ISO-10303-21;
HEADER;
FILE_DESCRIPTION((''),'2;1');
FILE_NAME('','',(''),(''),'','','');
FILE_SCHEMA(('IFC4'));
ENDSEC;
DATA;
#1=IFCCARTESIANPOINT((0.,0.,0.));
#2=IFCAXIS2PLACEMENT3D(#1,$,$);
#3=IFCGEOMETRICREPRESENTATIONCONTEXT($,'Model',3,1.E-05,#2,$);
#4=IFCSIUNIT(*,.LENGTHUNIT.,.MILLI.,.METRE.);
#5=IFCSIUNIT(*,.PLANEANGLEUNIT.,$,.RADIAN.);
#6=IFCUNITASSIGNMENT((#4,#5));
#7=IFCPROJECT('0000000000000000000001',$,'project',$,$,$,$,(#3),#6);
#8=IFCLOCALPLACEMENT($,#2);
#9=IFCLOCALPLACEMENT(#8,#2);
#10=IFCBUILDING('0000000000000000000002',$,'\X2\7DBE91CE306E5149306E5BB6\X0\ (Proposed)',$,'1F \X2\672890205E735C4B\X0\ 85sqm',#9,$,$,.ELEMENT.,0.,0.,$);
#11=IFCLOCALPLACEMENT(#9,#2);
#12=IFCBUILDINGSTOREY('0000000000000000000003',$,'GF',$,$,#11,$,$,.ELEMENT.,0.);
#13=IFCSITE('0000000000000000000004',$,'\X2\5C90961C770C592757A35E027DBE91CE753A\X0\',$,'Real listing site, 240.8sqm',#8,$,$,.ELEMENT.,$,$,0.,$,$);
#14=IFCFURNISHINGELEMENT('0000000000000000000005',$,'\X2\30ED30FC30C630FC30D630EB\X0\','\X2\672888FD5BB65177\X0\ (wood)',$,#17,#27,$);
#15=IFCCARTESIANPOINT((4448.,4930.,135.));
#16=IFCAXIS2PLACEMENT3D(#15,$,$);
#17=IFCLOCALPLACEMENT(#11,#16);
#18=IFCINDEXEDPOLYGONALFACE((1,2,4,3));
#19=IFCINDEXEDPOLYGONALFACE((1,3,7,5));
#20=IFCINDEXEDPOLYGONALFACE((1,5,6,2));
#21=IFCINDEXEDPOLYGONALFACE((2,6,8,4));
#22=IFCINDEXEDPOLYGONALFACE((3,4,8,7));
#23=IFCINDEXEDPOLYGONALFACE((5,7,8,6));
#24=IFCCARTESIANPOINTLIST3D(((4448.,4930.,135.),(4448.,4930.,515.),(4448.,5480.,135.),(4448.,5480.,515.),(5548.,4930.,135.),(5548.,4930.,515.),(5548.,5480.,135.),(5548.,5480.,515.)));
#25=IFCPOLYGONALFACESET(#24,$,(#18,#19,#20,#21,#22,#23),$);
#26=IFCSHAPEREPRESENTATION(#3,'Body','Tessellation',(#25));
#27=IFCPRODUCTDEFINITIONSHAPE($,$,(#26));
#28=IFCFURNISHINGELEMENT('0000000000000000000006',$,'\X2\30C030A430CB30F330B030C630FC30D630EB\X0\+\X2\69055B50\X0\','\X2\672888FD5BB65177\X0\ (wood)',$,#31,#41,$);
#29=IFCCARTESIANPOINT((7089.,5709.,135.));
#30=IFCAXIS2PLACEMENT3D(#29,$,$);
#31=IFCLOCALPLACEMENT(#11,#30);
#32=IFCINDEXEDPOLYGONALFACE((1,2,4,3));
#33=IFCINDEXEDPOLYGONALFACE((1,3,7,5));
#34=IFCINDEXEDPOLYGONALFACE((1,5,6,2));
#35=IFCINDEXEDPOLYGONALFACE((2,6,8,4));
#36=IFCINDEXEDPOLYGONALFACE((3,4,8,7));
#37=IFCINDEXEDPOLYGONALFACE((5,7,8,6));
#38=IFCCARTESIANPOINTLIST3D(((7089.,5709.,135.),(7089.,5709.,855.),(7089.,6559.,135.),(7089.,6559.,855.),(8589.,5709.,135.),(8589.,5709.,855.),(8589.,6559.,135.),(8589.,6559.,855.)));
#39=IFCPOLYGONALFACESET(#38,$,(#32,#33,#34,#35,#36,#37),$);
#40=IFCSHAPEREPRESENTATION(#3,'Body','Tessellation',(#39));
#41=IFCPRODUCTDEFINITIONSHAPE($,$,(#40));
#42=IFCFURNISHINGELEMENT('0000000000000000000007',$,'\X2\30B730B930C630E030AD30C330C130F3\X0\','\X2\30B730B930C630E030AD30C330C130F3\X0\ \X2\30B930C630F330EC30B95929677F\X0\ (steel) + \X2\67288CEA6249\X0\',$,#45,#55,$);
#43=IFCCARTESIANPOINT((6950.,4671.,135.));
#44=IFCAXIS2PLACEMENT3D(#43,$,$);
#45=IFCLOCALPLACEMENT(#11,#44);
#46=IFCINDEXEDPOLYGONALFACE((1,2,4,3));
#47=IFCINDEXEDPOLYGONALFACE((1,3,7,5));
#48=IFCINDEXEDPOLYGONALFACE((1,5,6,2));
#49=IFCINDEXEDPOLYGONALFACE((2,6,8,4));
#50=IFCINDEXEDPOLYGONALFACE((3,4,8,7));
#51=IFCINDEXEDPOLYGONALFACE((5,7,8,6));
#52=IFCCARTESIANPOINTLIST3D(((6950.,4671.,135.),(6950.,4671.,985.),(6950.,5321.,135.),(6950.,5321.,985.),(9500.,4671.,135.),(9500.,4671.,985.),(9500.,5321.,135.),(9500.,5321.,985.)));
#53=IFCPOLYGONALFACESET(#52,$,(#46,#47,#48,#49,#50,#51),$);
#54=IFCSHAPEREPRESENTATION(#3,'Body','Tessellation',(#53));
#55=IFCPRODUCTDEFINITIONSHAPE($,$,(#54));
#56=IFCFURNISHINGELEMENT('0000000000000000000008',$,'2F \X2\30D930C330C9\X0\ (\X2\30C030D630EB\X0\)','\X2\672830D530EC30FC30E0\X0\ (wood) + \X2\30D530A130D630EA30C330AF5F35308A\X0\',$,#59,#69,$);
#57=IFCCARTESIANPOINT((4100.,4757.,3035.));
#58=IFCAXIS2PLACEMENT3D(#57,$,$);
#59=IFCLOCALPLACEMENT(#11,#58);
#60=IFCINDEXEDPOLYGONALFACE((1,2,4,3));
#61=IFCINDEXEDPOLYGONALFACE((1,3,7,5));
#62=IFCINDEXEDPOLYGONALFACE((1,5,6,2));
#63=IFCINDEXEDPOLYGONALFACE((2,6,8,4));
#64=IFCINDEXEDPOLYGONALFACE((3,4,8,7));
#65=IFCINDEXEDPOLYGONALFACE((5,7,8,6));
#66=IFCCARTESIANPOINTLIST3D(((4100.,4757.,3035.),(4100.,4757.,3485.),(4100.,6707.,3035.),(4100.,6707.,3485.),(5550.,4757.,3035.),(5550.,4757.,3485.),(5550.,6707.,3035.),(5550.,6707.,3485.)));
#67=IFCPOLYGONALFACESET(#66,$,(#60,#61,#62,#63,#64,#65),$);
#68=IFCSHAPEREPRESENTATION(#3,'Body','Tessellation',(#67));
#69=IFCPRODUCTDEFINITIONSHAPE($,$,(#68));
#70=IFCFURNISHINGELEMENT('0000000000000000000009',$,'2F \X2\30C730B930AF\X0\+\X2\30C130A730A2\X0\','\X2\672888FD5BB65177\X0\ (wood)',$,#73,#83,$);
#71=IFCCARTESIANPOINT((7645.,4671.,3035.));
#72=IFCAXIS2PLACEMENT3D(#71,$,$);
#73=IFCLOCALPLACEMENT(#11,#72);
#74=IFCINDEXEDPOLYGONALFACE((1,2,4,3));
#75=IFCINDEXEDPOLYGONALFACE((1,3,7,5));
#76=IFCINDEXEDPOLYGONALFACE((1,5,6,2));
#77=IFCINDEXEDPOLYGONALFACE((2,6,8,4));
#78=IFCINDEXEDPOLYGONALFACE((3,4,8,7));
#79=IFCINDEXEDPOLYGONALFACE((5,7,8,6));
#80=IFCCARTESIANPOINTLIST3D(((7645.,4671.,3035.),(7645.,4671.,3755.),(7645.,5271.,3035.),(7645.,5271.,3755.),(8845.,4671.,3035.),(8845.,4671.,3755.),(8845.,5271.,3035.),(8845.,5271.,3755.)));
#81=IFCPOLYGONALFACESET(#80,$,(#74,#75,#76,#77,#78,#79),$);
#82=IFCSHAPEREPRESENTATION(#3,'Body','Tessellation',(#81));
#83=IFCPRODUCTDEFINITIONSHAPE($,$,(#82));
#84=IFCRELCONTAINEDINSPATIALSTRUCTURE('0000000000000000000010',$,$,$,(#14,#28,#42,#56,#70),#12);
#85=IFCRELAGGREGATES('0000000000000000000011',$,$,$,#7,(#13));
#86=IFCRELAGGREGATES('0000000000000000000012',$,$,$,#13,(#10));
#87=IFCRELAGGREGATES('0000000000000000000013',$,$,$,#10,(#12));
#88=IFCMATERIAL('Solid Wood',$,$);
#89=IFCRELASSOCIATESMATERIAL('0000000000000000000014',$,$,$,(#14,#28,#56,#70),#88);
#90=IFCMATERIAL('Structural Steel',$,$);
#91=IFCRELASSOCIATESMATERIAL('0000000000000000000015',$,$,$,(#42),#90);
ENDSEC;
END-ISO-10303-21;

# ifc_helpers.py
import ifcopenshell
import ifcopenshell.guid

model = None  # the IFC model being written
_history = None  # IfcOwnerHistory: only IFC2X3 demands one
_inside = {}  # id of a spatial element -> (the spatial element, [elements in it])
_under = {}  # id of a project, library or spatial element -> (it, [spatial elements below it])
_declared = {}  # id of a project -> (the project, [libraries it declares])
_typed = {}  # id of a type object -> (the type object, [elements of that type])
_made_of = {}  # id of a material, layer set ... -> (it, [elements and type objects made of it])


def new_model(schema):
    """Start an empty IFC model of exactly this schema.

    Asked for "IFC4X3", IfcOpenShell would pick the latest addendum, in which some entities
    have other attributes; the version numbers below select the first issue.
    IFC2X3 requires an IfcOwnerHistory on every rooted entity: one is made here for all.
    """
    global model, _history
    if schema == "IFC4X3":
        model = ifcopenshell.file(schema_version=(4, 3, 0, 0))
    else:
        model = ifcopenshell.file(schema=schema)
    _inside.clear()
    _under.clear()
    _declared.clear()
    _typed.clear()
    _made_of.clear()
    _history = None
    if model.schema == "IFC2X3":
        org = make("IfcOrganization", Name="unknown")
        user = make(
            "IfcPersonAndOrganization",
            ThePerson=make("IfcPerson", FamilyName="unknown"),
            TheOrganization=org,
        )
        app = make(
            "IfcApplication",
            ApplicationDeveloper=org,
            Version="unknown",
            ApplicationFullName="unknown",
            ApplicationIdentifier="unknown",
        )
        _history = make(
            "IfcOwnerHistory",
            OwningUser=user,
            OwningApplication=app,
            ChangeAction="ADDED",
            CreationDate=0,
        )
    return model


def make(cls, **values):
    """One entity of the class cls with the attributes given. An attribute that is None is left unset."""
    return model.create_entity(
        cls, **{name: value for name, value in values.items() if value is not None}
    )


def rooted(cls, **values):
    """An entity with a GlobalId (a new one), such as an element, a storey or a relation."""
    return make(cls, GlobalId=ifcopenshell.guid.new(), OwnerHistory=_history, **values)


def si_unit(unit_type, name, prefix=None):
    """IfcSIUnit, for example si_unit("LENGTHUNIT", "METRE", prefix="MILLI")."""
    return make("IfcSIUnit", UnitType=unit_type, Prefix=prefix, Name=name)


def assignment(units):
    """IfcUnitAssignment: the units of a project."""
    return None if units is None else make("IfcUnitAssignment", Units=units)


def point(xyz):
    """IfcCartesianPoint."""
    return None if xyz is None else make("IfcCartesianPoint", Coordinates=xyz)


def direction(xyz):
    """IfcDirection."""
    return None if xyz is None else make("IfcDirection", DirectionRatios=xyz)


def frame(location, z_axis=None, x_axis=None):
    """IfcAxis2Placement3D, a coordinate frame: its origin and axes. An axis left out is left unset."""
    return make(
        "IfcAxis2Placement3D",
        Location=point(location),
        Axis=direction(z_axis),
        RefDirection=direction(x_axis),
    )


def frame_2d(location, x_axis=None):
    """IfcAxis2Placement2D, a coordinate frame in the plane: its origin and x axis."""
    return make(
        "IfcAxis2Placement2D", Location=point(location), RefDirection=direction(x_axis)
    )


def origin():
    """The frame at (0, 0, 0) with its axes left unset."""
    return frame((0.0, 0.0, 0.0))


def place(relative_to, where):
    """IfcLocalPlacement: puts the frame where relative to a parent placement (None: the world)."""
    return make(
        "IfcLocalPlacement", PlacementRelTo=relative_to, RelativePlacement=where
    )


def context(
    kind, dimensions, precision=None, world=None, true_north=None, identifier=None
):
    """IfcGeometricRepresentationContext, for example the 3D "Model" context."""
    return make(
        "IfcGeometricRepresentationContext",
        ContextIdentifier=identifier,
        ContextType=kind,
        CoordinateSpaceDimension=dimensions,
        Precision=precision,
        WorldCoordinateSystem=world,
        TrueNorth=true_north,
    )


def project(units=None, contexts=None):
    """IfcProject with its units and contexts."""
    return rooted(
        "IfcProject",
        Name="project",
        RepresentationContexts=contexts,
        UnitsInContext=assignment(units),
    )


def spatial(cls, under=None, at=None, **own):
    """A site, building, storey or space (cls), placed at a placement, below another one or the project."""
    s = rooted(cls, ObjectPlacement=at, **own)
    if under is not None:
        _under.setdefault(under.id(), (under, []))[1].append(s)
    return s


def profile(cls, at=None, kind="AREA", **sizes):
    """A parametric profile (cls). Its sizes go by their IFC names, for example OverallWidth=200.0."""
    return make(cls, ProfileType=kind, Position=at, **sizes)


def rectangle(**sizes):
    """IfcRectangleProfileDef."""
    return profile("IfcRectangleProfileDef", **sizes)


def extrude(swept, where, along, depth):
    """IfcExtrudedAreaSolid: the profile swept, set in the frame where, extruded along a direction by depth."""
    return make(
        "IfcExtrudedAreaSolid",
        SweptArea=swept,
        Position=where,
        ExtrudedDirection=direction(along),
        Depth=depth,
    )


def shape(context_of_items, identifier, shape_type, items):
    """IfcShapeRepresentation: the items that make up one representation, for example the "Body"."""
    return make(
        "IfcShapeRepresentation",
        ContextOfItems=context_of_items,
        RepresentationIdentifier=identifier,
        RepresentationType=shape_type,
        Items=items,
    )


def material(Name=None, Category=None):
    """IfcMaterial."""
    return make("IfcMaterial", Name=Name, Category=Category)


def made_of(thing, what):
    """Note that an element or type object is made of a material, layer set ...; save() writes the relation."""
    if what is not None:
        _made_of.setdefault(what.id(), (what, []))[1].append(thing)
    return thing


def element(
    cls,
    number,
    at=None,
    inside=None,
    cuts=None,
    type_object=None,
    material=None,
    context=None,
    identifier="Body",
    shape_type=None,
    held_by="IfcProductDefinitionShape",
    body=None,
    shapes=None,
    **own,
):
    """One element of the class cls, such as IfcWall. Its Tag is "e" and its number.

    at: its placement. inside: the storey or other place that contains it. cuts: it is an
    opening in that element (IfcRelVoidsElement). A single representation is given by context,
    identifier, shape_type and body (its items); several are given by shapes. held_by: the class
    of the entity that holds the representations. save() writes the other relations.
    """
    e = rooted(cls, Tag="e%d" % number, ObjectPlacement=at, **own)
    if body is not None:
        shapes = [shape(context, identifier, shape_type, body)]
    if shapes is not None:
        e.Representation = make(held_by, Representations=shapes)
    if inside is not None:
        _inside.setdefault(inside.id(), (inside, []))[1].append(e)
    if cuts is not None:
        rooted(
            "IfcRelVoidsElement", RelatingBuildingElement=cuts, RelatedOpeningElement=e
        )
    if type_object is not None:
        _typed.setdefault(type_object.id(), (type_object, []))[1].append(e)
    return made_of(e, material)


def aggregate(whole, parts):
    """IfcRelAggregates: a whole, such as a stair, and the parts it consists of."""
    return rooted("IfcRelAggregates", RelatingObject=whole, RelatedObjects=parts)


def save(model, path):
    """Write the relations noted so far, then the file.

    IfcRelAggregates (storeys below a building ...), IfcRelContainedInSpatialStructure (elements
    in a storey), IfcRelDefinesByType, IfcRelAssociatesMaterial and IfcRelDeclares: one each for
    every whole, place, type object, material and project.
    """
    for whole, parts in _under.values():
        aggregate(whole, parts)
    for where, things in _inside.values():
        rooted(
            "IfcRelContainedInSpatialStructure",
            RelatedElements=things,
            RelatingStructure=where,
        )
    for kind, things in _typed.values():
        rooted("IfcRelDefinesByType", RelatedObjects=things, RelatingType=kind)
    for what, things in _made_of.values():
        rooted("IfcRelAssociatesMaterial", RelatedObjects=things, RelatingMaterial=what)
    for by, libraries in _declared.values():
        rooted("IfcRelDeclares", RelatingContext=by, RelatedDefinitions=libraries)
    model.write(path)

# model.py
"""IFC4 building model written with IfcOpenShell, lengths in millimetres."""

from ifc_helpers import new_model, si_unit, frame, frame_2d, origin, place, context, project, spatial, rectangle, extrude, material, element, save


model = new_model("IFC4")

# Units and contexts
model_context = context("Model", 3, precision=1e-05, world=origin())
ifc_project = project(units=[si_unit("LENGTHUNIT", "METRE", prefix="MILLI"), si_unit("PLANEANGLEUNIT", "RADIAN")], contexts=[model_context])

# Site, building, storey
site_placement = place(None, origin())
site = spatial("IfcSite", under=ifc_project, at=site_placement, Name="岐阜県大垣市綾野町", ObjectType="Real listing site, 240.8sqm", CompositionType="ELEMENT", RefElevation=0.0)
building_placement = place(site_placement, origin())
building = spatial("IfcBuilding", under=site, at=building_placement, Name="綾野の光の家 (Proposed)", ObjectType="1F 木造平屋 85sqm", CompositionType="ELEMENT", ElevationOfRefHeight=0.0, ElevationOfTerrain=0.0)
storey_placement = place(building_placement, origin())
storey = spatial("IfcBuildingStorey", under=building, at=storey_placement, Name="GF", CompositionType="ELEMENT", Elevation=0.0)

# Shared definitions
ifc_material_1 = material(Name="Solid Wood")

# Shared definitions
ifc_material_2 = material(Name="Structural Steel")

# Furnishing elements
furnishing_1_placement = place(storey_placement, frame((4448.0, 4930.0, 135.0)))
element("IfcFurnishingElement", 1, at=furnishing_1_placement, inside=storey, material=ifc_material_1, Name="ローテーブル", Description="木製家具 (wood)", context=model_context, shape_type="SweptSolid", body=[
    extrude(rectangle(XDim=1100.0, YDim=550.0, at=frame_2d((550.0, 275.0))), frame((4448.0, 4930.0, 135.0)), (0.0, 0.0, 1.0), 380.0),
])
furnishing_2_placement = place(storey_placement, frame((7089.0, 5709.0, 135.0)))
element("IfcFurnishingElement", 2, at=furnishing_2_placement, inside=storey, material=ifc_material_1, Name="ダイニングテーブル+椅子", Description="木製家具 (wood)", context=model_context, shape_type="SweptSolid", body=[
    extrude(rectangle(XDim=1500.0, YDim=850.0, at=frame_2d((750.0, 425.0))), frame((7089.0, 5709.0, 135.0)), (0.0, 0.0, 1.0), 720.0),
])
furnishing_3_placement = place(storey_placement, frame((6950.0, 4671.0, 135.0)))
element("IfcFurnishingElement", 3, at=furnishing_3_placement, inside=storey, material=ifc_material_2, Name="システムキッチン", Description="システムキッチン ステンレス天板 (steel) + 木質扉", context=model_context, shape_type="SweptSolid", body=[
    extrude(rectangle(XDim=2550.0, YDim=650.0, at=frame_2d((1275.0, 325.0))), frame((6950.0, 4671.0, 135.0)), (0.0, 0.0, 1.0), 850.0),
])
furnishing_4_placement = place(storey_placement, frame((4100.0, 4757.0, 3035.0)))
element("IfcFurnishingElement", 4, at=furnishing_4_placement, inside=storey, material=ifc_material_1, Name="2F ベッド (ダブル)", Description="木フレーム (wood) + ファブリック張り", context=model_context, shape_type="SweptSolid", body=[
    extrude(rectangle(XDim=1450.0, YDim=1950.0, at=frame_2d((725.0, 975.0))), frame((4100.0, 4757.0, 3035.0)), (0.0, 0.0, 1.0), 450.0),
])
furnishing_5_placement = place(storey_placement, frame((7645.0, 4671.0, 3035.0)))
element("IfcFurnishingElement", 5, at=furnishing_5_placement, inside=storey, material=ifc_material_1, Name="2F デスク+チェア", Description="木製家具 (wood)", context=model_context, shape_type="SweptSolid", body=[
    extrude(rectangle(XDim=1200.0, YDim=600.0, at=frame_2d((600.0, 300.0))), frame((7645.0, 4671.0, 3035.0)), (0.0, 0.0, 1.0), 720.0),
])

save(model, "model.ifc")
